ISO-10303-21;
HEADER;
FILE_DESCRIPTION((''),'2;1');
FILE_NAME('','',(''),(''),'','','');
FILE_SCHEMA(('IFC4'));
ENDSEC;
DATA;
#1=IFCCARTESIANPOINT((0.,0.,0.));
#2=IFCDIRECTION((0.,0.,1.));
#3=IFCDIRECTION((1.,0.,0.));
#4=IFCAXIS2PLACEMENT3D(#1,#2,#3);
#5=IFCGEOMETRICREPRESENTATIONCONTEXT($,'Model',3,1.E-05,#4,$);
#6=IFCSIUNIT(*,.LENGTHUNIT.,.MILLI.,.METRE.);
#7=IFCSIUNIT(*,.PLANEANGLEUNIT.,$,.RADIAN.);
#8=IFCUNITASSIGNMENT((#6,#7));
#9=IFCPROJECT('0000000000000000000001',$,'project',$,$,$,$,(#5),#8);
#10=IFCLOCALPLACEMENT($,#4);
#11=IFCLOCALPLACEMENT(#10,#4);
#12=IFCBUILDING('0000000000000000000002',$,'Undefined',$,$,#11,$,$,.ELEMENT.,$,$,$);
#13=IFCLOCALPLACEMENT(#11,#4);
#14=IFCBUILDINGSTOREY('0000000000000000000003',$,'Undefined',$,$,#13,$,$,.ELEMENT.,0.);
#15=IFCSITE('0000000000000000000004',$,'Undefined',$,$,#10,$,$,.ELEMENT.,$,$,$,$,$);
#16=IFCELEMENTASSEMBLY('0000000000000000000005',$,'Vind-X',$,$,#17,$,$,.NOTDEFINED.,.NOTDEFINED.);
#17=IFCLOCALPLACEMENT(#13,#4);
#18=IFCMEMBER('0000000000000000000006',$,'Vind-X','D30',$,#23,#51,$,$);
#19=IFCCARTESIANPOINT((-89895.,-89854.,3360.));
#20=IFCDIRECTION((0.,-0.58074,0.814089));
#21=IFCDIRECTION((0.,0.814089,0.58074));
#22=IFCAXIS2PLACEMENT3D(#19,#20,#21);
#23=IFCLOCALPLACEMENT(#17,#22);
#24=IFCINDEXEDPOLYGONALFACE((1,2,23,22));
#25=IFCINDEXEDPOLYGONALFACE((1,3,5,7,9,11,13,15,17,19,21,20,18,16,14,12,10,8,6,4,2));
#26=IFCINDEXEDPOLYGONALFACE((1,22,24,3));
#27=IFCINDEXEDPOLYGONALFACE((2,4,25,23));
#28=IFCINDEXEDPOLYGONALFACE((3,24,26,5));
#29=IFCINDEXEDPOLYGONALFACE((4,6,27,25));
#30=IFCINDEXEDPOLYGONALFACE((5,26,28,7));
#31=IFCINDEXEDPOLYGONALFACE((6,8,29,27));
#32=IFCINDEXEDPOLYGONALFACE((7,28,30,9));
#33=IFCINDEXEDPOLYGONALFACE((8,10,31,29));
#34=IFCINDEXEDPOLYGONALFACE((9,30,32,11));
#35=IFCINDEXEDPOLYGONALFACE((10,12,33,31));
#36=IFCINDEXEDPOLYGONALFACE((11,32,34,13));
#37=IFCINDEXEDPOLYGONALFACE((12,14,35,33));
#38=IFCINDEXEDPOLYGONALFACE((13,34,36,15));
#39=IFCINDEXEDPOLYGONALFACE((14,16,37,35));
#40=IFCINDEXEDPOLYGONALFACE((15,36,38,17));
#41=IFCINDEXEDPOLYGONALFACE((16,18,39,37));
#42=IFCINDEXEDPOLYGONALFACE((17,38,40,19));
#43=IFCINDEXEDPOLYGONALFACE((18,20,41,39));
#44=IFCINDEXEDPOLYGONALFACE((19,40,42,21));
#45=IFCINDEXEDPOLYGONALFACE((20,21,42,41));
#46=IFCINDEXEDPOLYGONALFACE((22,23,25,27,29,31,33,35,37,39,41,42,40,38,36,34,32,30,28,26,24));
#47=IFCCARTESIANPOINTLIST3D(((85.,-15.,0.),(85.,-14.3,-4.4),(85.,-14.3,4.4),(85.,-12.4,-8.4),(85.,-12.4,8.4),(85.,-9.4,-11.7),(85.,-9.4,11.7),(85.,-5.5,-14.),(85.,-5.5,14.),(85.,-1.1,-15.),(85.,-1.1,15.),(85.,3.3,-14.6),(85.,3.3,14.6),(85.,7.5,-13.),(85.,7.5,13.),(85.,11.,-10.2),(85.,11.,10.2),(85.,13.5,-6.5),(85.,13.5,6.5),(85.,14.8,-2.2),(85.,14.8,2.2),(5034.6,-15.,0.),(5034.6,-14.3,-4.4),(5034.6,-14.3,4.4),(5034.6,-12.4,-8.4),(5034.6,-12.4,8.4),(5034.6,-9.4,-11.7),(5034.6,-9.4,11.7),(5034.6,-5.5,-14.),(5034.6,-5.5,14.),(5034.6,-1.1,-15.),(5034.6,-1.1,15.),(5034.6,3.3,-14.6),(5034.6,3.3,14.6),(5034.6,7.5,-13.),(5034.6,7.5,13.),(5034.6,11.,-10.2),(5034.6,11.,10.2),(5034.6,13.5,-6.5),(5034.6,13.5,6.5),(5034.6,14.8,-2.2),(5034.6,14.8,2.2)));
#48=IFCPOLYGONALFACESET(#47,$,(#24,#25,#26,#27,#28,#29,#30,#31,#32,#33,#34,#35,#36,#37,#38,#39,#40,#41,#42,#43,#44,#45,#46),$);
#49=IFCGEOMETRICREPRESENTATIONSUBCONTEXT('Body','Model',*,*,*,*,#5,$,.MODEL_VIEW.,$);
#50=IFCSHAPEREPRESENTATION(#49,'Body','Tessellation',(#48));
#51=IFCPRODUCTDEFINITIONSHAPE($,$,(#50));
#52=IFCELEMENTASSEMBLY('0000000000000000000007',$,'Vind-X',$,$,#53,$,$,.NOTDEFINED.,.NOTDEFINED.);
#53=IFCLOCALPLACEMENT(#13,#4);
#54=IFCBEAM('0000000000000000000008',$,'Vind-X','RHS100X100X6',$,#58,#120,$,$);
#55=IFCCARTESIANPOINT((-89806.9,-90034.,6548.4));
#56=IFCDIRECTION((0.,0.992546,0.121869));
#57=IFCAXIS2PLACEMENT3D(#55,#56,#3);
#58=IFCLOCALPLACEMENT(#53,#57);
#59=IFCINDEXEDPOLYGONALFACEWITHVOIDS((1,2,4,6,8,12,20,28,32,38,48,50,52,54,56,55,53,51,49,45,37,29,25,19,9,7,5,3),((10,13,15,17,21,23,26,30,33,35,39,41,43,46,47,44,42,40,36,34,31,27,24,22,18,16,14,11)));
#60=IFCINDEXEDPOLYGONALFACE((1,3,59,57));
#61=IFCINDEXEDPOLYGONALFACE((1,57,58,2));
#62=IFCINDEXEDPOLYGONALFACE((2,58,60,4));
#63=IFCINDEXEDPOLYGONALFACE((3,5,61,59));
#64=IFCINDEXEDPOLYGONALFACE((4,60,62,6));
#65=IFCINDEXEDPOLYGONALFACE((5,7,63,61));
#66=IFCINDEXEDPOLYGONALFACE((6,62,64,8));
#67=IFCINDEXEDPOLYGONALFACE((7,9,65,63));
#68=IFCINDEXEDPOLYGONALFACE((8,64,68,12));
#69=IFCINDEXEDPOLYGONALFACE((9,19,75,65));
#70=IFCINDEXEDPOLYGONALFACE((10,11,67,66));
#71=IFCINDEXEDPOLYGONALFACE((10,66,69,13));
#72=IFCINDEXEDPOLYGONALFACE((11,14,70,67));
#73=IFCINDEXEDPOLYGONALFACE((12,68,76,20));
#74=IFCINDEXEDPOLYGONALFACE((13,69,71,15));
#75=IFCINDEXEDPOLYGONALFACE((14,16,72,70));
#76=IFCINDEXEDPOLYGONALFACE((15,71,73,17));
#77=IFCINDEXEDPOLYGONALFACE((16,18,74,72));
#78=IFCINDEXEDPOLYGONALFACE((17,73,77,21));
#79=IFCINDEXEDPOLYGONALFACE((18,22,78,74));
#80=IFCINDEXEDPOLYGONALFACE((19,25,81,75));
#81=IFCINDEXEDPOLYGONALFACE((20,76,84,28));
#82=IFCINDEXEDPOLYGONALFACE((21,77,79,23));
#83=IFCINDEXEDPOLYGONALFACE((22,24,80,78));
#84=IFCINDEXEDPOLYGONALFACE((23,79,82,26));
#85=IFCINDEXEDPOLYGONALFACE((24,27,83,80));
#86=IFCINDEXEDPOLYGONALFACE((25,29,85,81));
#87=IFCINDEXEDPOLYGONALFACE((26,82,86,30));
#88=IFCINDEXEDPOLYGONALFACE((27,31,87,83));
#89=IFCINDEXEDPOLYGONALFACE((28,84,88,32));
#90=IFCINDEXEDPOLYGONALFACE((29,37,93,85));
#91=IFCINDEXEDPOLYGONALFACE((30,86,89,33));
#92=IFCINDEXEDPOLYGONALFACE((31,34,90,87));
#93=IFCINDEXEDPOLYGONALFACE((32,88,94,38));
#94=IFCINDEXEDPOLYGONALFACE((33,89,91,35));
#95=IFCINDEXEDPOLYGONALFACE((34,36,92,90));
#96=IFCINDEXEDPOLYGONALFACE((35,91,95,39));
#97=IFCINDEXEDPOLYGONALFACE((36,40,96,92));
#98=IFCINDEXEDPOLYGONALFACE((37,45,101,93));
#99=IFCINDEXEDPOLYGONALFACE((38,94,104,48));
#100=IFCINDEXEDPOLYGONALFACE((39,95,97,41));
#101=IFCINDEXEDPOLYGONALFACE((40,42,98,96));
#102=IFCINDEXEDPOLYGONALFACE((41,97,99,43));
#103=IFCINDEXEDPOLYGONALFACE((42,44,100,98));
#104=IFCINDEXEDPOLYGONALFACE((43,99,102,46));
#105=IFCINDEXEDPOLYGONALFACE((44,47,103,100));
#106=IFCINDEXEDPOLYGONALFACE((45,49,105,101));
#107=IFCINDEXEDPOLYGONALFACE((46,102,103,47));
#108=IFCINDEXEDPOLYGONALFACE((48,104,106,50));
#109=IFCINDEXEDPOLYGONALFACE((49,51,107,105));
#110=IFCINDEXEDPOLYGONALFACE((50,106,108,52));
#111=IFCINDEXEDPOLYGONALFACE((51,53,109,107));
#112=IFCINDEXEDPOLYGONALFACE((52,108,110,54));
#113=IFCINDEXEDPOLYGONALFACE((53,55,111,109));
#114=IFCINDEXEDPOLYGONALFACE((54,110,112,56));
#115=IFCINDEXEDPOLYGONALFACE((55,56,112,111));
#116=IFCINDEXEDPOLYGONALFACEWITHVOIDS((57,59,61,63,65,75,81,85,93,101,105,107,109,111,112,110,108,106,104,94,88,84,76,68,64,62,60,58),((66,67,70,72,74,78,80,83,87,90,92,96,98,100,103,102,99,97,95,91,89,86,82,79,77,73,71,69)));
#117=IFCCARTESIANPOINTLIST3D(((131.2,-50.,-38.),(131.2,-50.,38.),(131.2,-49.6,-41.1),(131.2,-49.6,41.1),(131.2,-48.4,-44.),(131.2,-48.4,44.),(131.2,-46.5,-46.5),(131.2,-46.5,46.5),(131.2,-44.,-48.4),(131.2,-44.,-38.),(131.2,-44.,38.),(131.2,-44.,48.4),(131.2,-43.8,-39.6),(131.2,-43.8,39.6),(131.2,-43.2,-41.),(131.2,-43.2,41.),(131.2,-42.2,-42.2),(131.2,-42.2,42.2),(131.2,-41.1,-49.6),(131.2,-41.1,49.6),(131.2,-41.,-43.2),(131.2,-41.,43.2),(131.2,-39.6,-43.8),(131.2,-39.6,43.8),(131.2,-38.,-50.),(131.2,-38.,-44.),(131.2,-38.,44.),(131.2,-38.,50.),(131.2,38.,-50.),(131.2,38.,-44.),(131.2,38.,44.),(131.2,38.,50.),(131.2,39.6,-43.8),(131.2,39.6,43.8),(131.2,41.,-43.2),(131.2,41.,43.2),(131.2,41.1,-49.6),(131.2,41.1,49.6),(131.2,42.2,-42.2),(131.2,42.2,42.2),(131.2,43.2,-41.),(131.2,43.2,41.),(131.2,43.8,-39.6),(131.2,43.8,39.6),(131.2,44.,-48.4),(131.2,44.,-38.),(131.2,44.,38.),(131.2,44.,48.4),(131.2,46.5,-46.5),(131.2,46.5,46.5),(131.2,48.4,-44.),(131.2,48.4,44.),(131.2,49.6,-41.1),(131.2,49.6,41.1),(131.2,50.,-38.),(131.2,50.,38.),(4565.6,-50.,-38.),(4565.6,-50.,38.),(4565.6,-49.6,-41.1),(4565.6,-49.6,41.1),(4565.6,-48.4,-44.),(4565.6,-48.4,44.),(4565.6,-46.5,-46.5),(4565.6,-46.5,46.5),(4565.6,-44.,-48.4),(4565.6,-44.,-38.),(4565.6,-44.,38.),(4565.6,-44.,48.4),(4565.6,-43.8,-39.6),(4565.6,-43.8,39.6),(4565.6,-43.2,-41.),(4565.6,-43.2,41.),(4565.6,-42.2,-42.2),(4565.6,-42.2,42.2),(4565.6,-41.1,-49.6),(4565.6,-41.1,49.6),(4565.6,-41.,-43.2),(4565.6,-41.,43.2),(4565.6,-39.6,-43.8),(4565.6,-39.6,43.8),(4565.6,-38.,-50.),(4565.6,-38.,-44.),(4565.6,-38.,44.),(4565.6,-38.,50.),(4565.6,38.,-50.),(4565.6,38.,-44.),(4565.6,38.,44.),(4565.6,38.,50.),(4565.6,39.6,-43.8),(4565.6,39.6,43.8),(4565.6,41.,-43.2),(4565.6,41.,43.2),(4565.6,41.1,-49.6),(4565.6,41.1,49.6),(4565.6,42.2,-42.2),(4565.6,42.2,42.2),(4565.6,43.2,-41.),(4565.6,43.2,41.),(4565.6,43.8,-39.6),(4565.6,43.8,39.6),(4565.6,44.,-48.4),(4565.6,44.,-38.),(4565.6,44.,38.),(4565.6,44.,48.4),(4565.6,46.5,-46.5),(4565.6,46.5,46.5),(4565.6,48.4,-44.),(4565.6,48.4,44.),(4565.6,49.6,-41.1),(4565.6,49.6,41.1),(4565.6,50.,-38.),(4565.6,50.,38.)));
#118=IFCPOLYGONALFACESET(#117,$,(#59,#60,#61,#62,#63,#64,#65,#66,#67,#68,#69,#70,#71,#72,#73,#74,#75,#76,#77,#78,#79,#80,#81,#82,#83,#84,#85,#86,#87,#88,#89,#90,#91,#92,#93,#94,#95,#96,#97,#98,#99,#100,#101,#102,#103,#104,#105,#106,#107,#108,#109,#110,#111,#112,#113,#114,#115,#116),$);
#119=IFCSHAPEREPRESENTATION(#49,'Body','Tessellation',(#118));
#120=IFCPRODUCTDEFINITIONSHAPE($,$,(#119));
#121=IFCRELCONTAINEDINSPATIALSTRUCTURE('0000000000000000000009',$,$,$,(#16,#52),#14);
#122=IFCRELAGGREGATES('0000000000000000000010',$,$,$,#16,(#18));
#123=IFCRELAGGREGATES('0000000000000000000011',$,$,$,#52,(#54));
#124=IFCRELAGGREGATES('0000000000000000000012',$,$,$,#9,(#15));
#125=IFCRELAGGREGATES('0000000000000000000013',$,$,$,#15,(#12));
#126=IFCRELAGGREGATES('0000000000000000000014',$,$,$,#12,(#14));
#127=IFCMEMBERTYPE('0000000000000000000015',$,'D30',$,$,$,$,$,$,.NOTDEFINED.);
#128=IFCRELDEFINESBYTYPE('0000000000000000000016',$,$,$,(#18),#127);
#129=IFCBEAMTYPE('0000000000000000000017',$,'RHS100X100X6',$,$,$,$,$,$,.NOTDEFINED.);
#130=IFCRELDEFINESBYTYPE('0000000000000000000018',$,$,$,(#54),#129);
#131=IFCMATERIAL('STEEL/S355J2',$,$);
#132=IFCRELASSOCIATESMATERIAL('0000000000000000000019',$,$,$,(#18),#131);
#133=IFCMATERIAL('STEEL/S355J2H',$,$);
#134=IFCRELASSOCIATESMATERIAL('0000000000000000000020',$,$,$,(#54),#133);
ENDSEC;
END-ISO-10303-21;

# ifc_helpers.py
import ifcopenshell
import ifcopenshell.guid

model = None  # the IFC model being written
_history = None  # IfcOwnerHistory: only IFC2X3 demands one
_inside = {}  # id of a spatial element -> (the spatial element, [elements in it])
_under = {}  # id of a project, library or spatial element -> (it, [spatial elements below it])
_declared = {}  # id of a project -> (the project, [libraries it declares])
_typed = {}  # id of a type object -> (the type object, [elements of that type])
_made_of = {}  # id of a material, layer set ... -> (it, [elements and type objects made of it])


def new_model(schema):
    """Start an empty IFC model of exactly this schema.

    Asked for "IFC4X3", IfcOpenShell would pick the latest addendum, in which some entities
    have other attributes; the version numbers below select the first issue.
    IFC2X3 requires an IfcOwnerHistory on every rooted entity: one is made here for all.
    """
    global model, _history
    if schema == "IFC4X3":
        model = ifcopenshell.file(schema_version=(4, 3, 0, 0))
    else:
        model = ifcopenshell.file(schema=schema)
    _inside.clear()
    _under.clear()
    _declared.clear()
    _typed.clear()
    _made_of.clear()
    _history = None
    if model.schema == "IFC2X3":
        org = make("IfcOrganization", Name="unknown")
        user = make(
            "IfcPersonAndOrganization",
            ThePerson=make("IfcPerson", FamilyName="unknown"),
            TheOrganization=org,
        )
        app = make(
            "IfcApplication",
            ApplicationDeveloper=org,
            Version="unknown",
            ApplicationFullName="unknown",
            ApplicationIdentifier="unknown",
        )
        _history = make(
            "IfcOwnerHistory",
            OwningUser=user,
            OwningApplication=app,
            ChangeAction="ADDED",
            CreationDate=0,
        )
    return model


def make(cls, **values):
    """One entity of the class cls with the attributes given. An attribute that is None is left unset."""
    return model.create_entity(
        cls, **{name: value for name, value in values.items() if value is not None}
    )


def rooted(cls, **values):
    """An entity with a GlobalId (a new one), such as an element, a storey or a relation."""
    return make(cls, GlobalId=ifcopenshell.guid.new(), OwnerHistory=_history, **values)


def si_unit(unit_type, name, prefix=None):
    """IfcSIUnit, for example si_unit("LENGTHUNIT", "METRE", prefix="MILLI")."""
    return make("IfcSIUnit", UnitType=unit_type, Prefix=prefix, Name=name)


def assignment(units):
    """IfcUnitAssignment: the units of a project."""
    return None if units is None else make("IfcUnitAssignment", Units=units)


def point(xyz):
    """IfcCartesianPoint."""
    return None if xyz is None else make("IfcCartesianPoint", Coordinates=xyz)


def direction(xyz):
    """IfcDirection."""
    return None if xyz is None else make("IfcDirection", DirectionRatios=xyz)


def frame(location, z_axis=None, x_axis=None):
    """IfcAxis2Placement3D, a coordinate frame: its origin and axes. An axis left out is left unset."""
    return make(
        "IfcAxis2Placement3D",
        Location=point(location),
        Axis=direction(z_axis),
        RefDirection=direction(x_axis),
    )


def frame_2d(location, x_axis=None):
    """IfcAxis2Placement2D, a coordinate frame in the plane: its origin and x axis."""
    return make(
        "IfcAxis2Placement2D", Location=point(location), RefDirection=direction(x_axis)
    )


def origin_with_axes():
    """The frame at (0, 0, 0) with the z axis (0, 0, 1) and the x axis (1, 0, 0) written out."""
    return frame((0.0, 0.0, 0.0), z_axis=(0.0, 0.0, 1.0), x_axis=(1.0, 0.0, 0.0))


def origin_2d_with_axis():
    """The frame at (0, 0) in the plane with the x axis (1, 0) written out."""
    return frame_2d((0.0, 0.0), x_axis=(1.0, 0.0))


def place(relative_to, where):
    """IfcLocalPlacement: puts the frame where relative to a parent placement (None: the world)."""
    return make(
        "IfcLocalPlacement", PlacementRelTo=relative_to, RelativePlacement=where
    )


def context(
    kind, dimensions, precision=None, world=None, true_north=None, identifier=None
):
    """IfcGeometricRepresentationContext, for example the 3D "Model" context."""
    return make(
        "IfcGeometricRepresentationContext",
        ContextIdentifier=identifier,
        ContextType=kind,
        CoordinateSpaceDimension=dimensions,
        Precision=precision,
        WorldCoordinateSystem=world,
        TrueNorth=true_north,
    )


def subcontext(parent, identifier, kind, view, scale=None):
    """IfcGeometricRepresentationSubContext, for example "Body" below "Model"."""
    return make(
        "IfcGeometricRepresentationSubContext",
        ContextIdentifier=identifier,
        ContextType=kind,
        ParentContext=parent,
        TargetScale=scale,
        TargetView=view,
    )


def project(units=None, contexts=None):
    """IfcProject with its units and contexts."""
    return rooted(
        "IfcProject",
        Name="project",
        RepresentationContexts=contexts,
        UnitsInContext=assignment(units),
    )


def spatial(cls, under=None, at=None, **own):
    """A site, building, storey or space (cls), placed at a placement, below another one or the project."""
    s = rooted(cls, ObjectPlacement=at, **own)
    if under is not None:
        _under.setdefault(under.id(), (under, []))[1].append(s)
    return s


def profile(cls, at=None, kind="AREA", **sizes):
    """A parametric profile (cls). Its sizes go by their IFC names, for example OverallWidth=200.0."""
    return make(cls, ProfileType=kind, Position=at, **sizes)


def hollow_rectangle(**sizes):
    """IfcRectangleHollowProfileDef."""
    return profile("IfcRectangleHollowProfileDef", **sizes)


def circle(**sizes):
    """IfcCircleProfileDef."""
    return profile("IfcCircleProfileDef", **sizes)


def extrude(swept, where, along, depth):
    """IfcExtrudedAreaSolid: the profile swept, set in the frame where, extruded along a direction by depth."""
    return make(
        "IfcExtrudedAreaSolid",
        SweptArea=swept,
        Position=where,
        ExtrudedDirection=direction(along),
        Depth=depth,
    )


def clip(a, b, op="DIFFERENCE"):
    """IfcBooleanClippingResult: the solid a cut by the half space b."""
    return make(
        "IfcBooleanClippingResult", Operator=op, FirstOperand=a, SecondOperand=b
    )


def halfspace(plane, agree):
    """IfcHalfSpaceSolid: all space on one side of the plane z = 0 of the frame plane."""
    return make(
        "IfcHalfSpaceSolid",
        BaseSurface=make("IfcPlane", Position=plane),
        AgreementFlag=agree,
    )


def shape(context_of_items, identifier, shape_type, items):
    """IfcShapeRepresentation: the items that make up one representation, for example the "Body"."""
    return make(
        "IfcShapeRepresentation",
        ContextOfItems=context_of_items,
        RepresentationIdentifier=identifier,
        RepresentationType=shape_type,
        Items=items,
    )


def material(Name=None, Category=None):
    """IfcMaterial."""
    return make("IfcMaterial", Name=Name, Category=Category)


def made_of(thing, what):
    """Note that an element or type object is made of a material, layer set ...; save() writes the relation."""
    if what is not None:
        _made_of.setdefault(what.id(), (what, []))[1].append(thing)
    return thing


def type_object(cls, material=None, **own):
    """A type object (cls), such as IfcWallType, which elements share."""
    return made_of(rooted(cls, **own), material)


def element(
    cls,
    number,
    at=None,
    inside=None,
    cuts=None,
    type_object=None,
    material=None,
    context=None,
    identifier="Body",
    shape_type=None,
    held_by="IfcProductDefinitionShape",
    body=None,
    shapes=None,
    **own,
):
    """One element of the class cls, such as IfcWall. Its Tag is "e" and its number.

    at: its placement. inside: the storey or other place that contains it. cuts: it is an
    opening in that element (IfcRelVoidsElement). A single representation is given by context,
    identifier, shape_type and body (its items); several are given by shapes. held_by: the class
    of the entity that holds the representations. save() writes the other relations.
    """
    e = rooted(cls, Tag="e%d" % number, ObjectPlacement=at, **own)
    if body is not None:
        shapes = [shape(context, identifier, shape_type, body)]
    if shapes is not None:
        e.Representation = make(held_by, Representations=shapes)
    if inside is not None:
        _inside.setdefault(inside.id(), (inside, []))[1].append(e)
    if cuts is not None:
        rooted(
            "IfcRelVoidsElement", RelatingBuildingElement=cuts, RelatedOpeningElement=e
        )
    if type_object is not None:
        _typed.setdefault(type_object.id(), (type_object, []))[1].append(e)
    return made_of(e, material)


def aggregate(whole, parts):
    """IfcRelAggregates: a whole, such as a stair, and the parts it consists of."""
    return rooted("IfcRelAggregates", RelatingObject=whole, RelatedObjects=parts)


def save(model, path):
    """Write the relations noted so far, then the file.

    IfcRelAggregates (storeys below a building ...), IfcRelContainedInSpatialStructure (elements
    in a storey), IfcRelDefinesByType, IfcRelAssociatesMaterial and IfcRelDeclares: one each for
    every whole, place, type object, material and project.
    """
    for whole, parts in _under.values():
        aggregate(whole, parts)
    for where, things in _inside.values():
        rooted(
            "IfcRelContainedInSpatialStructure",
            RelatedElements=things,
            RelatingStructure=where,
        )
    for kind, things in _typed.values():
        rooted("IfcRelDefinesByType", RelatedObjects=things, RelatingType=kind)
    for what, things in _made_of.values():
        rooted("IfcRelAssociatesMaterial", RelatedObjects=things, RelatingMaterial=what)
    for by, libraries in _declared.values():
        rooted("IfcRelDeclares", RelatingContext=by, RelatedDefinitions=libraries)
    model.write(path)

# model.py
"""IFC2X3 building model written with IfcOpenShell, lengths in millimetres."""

from ifc_helpers import new_model, si_unit, frame, origin_with_axes, origin_2d_with_axis, place, context, subcontext, project, spatial, hollow_rectangle, circle, extrude, clip, halfspace, material, type_object, element, aggregate, save


model = new_model("IFC2X3")

# Units and contexts
model_context = context("Model", 3, precision=1e-05, world=origin_with_axes())
body_context = subcontext(model_context, "Body", "Model", "MODEL_VIEW")
ifc_project = project(units=[si_unit("LENGTHUNIT", "METRE", prefix="MILLI"), si_unit("PLANEANGLEUNIT", "RADIAN")], contexts=[model_context])

# Site, building, storey
site_placement = place(None, origin_with_axes())
site = spatial("IfcSite", under=ifc_project, at=site_placement, Name="Undefined", CompositionType="ELEMENT")
building_placement = place(site_placement, origin_with_axes())
building = spatial("IfcBuilding", under=site, at=building_placement, Name="Undefined", CompositionType="ELEMENT")
storey_placement = place(building_placement, origin_with_axes())
storey = spatial("IfcBuildingStorey", under=building, at=storey_placement, Name="Undefined", CompositionType="ELEMENT", Elevation=0.0)

# Shared definitions
ifc_material_1 = material(Name="STEEL/S355J2")

# Element assembly, member
member_type_1 = type_object("IfcMemberType", Name="D30", PredefinedType="NOTDEFINED")
assembly_1_placement = place(storey_placement, origin_with_axes())
assembly_1 = element("IfcElementAssembly", 1, at=assembly_1_placement, inside=storey, Name="Vind-X", AssemblyPlace="NOTDEFINED", PredefinedType="NOTDEFINED")
member_1_placement = place(assembly_1_placement, frame((-89895.0, -89854.0, 3360.0), z_axis=(0.0, -0.58074, 0.814089), x_axis=(0.0, 0.814089, 0.58074)))
member_1 = element("IfcMember", 2, at=member_1_placement, type_object=member_type_1, material=ifc_material_1, Name="Vind-X", Description="D30", context=body_context, shape_type="Clipping", body=[
    clip(clip(extrude(circle(Radius=15.0, at=origin_2d_with_axis()), frame((5699.6, 0.0, 0.0), z_axis=(-1.0, 0.0, 0.0), x_axis=(0.0, -1.0, 0.0)), (0.0, 0.0, 1.0), 5699.6), halfspace(frame((5034.6, -6.0, 10.2), z_axis=(1.0, 0.0, 0.0), x_axis=(0.0, 1.0, 0.0)), False)), halfspace(frame((85.0, -6.0, 16.0), z_axis=(1.0, 0.0, 0.0), x_axis=(0.0, 1.0, 0.0)), True)),
])

# Element assembly, beam
assembly_2_placement = place(storey_placement, origin_with_axes())
assembly_2 = element("IfcElementAssembly", 3, at=assembly_2_placement, inside=storey, Name="Vind-X", AssemblyPlace="NOTDEFINED", PredefinedType="NOTDEFINED")
ifc_material_2 = material(Name="STEEL/S355J2H")
beam_type_1 = type_object("IfcBeamType", Name="RHS100X100X6", PredefinedType="NOTDEFINED")
beam_1_placement = place(assembly_2_placement, frame((-89806.9, -90034.0, 6548.4), z_axis=(0.0, 0.992546, 0.121869), x_axis=(1.0, 0.0, 0.0)))
beam_1 = element("IfcBeam", 4, at=beam_1_placement, type_object=beam_type_1, material=ifc_material_2, Name="Vind-X", Description="RHS100X100X6", context=body_context, shape_type="Clipping", body=[
    clip(clip(extrude(hollow_rectangle(XDim=100.0, YDim=100.0, WallThickness=6.0, InnerFilletRadius=6.0, OuterFilletRadius=12.0, at=origin_2d_with_axis()), frame((4644.6, 0.0, 0.0), z_axis=(-1.0, 0.0, 0.0), x_axis=(0.0, -1.0, 0.0)), (0.0, 0.0, 1.0), 4644.6), halfspace(frame((4565.6, 22.5, 0.0), z_axis=(-1.0, 0.0, 0.0), x_axis=(0.0, 0.0, 1.0)), True)), halfspace(frame((131.2, 22.5, 0.0), z_axis=(1.0, 0.0, 0.0), x_axis=(0.0, 0.0, -1.0)), True)),
])

aggregate(assembly_1, [member_1])
aggregate(assembly_2, [beam_1])

save(model, "model.ifc")
